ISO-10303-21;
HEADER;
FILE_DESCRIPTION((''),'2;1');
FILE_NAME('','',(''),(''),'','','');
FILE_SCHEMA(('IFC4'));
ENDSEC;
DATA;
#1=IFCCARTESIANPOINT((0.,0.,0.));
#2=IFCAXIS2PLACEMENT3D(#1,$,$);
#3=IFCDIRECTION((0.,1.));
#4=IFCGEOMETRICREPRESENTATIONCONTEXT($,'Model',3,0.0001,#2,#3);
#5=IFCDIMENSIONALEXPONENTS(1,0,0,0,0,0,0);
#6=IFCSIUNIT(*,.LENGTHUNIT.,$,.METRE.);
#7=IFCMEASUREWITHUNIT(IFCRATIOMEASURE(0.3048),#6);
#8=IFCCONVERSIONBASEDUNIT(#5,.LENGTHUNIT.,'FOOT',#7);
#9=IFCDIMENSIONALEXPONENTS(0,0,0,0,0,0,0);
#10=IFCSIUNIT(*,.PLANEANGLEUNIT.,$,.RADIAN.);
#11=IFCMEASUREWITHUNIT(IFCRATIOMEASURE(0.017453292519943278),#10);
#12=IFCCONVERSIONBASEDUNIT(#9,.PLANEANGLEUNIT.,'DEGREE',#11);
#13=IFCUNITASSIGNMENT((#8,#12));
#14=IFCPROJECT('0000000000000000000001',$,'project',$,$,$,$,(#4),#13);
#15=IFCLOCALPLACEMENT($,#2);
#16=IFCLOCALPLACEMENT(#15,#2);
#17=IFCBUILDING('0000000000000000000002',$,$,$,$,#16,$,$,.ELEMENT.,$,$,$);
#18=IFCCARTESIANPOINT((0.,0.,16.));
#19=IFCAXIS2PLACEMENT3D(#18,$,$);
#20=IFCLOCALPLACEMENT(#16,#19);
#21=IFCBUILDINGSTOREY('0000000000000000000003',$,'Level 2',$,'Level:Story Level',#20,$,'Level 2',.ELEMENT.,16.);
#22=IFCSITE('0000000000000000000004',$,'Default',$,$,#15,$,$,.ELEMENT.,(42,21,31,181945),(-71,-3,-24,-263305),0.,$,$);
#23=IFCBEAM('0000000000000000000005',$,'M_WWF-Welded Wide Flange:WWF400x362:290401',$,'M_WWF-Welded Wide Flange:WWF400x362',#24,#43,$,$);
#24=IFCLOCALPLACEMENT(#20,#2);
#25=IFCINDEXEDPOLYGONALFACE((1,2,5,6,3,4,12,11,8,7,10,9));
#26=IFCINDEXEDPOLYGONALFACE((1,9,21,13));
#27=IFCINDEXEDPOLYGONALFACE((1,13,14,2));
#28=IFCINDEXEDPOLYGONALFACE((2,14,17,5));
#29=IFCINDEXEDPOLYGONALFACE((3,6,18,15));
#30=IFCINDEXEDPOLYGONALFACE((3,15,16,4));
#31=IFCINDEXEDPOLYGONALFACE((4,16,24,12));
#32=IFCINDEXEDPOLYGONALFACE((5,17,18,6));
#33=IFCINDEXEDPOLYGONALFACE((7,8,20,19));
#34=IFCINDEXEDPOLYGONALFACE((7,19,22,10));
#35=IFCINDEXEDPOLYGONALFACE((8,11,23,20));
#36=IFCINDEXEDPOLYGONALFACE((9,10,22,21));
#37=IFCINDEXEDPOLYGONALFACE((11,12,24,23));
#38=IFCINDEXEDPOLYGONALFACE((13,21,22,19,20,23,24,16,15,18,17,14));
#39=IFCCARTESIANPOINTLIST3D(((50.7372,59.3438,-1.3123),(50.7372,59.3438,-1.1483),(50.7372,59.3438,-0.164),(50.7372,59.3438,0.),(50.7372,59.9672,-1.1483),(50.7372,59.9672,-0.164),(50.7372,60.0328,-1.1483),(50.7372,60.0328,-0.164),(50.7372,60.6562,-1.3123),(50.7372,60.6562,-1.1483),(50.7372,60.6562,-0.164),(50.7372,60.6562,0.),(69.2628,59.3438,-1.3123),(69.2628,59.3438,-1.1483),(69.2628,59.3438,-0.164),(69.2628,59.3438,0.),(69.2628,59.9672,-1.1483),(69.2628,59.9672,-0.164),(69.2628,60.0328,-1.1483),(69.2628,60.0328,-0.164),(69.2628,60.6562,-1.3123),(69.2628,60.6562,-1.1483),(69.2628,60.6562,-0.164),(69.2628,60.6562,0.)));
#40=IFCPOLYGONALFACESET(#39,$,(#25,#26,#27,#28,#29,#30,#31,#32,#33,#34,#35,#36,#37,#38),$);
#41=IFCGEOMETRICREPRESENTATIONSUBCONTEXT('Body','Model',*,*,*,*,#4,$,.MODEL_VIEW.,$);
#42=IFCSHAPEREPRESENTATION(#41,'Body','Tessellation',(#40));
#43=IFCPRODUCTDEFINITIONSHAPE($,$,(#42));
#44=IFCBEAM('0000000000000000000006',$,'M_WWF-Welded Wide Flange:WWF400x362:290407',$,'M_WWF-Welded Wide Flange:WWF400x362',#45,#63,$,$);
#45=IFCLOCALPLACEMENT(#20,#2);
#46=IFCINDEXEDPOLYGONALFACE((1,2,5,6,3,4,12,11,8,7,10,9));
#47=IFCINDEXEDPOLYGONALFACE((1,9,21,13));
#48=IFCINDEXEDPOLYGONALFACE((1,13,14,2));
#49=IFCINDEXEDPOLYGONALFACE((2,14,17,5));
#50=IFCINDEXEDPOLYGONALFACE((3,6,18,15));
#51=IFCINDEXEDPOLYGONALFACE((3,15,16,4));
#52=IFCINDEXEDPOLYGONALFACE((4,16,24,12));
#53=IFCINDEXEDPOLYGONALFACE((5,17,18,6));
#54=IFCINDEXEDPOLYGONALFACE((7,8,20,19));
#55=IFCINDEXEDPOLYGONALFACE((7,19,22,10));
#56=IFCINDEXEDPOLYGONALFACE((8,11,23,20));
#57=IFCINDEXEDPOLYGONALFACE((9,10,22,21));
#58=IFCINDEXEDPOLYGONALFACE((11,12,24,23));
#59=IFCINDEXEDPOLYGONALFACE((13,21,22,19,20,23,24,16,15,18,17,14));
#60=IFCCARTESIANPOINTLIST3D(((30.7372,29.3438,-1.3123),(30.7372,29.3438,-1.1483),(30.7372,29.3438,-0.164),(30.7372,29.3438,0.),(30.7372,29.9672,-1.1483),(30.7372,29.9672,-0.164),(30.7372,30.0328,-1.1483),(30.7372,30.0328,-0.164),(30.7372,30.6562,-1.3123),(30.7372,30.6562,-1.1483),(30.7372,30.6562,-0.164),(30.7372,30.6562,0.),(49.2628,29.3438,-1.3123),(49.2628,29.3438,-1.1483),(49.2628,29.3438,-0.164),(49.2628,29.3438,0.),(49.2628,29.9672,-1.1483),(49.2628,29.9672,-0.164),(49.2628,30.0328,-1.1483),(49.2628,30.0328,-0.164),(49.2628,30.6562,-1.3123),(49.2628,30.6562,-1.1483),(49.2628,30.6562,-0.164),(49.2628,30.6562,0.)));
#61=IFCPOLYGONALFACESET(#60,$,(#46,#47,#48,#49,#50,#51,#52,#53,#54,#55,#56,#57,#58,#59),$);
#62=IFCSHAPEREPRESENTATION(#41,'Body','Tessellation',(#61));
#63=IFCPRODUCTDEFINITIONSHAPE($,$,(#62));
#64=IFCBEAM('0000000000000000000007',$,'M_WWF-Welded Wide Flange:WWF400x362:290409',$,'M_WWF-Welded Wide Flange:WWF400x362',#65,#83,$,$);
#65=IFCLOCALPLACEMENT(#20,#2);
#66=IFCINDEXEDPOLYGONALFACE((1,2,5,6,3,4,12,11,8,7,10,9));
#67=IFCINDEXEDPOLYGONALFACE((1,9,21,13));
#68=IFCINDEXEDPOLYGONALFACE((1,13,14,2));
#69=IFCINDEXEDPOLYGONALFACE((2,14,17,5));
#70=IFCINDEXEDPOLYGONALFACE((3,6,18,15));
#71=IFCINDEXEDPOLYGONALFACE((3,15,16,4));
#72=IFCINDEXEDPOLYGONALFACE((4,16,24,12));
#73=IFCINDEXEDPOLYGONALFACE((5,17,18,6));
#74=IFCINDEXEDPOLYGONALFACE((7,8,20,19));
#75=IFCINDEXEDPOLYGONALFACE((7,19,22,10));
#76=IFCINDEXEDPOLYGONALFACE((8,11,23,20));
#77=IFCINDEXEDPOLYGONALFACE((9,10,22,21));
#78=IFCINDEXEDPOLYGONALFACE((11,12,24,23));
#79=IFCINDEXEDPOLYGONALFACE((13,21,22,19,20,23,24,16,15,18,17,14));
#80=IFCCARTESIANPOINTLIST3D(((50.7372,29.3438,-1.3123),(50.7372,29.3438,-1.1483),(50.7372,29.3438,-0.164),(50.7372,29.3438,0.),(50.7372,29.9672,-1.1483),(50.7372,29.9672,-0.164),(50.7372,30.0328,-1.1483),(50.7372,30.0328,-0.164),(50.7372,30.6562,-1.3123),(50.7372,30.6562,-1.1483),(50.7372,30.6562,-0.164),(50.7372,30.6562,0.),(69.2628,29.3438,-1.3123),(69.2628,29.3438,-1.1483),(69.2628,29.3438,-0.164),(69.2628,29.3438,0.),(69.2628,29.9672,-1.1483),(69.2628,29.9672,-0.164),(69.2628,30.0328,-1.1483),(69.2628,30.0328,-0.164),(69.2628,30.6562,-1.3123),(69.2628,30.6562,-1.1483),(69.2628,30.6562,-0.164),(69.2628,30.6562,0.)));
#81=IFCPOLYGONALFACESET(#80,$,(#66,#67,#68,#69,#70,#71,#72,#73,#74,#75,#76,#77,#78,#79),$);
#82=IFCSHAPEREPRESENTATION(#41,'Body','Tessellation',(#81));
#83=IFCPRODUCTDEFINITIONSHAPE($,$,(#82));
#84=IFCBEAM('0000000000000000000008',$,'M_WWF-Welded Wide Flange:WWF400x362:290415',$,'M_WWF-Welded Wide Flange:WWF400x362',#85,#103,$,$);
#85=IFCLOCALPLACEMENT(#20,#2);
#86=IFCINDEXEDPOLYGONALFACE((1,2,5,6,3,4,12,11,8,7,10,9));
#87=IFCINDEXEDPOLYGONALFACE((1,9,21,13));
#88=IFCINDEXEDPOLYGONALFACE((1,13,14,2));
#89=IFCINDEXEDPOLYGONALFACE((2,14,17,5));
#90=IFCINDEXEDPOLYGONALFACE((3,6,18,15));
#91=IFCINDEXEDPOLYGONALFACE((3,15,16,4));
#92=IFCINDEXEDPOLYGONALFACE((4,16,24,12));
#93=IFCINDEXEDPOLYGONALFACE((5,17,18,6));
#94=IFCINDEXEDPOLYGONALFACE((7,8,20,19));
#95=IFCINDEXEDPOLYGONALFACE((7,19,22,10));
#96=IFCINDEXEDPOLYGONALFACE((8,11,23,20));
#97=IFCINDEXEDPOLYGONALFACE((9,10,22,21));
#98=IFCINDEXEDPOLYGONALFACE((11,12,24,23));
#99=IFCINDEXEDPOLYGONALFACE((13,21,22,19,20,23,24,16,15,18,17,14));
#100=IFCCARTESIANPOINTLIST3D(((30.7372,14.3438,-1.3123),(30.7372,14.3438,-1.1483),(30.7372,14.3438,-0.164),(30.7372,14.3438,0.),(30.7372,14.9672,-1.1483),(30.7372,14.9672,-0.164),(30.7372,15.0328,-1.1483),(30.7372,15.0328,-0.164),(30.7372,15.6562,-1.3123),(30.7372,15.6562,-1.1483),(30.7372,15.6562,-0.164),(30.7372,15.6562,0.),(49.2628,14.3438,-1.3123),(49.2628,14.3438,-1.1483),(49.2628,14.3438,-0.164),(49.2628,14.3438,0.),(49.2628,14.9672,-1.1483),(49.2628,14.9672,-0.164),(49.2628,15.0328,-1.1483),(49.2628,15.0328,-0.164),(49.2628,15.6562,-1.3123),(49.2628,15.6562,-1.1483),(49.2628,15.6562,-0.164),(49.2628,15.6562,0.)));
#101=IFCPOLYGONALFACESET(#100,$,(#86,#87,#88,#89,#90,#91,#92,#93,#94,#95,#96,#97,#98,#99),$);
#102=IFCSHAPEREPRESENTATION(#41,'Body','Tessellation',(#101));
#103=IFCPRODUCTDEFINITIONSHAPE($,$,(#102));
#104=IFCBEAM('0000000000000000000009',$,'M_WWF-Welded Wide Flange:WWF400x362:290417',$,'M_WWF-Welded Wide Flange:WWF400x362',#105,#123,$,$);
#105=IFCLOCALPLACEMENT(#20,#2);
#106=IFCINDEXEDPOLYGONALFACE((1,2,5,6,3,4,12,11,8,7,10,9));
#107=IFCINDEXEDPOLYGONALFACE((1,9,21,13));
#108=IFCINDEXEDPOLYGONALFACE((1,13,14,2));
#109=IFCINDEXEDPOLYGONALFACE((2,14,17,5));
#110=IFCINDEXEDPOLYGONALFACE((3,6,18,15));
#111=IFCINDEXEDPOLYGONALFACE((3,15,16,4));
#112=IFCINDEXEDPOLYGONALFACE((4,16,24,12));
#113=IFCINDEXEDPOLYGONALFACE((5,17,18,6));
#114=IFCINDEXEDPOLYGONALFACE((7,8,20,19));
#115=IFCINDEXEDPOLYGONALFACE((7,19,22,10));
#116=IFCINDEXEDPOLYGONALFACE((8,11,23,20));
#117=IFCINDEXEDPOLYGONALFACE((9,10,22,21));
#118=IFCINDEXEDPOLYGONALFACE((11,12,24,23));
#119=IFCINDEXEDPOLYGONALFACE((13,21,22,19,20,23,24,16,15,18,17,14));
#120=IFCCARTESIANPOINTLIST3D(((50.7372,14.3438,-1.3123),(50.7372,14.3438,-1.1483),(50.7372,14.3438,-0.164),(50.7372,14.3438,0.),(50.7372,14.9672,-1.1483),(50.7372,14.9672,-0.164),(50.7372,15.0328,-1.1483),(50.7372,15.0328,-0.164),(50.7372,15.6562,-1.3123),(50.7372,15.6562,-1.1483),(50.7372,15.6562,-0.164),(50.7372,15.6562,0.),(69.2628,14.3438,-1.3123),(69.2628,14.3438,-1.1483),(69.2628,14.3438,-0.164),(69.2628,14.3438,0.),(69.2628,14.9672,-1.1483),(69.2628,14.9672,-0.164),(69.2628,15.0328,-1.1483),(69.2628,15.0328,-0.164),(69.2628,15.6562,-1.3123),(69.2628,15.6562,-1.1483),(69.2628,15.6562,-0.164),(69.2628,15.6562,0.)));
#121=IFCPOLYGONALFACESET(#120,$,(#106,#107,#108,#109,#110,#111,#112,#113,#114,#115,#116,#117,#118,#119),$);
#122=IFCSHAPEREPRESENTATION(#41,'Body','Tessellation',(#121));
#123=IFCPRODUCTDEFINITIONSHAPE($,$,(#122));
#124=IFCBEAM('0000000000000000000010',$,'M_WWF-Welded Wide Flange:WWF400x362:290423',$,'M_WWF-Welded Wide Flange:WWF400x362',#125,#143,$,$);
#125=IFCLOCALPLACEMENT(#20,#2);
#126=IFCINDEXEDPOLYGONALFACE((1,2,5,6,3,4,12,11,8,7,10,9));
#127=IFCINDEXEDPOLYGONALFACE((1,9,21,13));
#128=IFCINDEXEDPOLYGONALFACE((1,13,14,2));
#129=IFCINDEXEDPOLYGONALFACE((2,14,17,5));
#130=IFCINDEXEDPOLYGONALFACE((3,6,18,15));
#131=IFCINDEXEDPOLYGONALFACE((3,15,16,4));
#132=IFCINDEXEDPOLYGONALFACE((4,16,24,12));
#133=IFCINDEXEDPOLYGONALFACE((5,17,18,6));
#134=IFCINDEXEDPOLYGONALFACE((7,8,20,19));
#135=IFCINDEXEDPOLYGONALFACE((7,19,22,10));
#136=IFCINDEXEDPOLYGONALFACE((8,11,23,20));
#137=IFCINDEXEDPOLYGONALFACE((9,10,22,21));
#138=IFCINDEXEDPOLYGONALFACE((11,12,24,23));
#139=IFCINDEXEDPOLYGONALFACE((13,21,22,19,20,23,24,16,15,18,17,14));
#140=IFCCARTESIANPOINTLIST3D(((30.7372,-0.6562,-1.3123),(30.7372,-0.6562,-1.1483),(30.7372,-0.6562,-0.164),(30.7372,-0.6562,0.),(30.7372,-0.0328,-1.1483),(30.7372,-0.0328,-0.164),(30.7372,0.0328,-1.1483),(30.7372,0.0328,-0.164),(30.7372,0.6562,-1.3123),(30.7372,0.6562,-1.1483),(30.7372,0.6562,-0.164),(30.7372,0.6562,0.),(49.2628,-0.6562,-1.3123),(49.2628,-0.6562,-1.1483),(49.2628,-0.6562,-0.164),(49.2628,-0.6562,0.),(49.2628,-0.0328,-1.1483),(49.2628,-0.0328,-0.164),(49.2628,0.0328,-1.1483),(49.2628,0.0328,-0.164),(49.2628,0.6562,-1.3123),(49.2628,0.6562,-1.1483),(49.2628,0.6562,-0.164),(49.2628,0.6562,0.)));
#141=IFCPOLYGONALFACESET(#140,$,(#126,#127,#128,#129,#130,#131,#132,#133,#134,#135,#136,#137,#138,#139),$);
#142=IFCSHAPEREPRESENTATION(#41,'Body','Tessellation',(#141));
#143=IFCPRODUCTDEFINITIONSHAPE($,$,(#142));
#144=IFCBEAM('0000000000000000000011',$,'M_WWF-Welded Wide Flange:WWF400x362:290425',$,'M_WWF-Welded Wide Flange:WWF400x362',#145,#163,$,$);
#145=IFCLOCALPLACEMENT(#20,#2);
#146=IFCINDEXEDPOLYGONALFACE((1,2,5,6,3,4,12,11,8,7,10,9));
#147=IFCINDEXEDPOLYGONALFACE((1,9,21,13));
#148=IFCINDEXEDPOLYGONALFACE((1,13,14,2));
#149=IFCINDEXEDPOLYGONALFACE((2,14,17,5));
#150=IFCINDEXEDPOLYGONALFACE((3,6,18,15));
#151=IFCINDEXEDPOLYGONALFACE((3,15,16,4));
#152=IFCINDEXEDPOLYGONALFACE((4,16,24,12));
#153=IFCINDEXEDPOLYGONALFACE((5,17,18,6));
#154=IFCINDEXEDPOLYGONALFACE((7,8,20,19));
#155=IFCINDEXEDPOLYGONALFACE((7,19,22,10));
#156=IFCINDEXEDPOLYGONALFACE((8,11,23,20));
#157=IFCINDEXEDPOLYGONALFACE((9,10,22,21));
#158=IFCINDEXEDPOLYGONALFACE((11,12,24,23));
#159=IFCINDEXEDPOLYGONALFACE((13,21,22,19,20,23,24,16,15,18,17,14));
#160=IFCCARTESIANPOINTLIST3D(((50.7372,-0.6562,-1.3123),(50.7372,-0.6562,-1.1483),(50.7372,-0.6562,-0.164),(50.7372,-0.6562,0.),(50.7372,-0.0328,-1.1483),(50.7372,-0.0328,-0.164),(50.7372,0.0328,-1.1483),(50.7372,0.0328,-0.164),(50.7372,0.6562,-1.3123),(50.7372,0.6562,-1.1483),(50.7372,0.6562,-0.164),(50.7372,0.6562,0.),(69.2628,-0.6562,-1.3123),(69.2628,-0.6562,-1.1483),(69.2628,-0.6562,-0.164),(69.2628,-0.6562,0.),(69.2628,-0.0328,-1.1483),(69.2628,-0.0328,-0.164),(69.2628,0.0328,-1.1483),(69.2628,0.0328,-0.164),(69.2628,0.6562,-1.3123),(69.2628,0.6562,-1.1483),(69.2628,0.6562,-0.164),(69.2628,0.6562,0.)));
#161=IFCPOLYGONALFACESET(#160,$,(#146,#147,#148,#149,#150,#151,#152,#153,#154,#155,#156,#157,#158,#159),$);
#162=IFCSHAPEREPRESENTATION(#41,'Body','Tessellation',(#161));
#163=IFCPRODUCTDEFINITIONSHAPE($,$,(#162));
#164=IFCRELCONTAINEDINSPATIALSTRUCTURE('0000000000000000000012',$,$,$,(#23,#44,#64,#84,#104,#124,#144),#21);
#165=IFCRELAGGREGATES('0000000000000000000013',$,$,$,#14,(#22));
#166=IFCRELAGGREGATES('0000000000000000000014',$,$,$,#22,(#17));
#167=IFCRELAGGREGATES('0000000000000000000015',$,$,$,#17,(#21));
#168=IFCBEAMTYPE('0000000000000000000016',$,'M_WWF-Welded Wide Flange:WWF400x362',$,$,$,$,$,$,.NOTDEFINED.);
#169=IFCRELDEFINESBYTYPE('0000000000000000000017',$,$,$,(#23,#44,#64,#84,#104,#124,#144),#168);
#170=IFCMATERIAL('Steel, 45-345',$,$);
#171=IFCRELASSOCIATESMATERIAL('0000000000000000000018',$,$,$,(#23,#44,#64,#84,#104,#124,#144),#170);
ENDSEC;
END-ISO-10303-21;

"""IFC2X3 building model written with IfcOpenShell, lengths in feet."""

from ifc_helpers import new_model, entity, si_unit, converted_unit, direction, frame, frame_2d, origin, place, context, subcontext, project, spatial, i_section, extrude, material, type_object, element, save


model = new_model("IFC2X3")

# Units and contexts
model_context = context("Model", 3, precision=0.0001, world=origin(), true_north=direction((0.0, 1.0)))
body_context = subcontext(model_context, "Body", "Model", "MODEL_VIEW")
ifc_project = project(units=[converted_unit("LENGTHUNIT", "FOOT", entity("IfcRatioMeasure", 0.3048), si_unit("LENGTHUNIT", "METRE"), dimensions=[1, 0, 0, 0, 0, 0, 0]), converted_unit("PLANEANGLEUNIT", "DEGREE", entity("IfcRatioMeasure", 0.017453292519943278), si_unit("PLANEANGLEUNIT", "RADIAN"), dimensions=[0, 0, 0, 0, 0, 0, 0])], contexts=[model_context])

# Site, building, storey
site_placement = place(None, origin())
site = spatial("IfcSite", under=ifc_project, at=site_placement, Name="Default", CompositionType="ELEMENT", RefLatitude=(42, 21, 31, 181945), RefLongitude=(-71, -3, -24, -263305), RefElevation=0.0)
building_placement = place(site_placement, origin())
building = spatial("IfcBuilding", under=site, at=building_placement, CompositionType="ELEMENT")
storey_placement = place(building_placement, frame((0.0, 0.0, 16.0)))
storey = spatial("IfcBuildingStorey", under=building, at=storey_placement, Name="Level 2", ObjectType="Level:Story Level", LongName="Level 2", CompositionType="ELEMENT", Elevation=16.0)

# Shared definitions
ifc_material = material(Name="Steel, 45-345")

# Beams
beam_type = type_object("IfcBeamType", Name="M_WWF-Welded Wide Flange:WWF400x362", PredefinedType="NOTDEFINED")
beam_1_placement = place(storey_placement, frame((50.0, 60.0, 0.0)))
element("IfcBeam", 1, at=beam_1_placement, inside=storey, type_object=beam_type, material=ifc_material, Name="M_WWF-Welded Wide Flange:WWF400x362:290401", ObjectType="M_WWF-Welded Wide Flange:WWF400x362", context=body_context, shape_type="SweptSolid", body=[
    extrude(i_section(OverallWidth=1.3123, OverallDepth=1.3123, WebThickness=0.0656, FlangeThickness=0.164, at=frame_2d((0.0, 0.0), x_axis=(0.0, 1.0))), frame((0.7372, 0.0, -0.6562), z_axis=(1.0, 0.0, 0.0), x_axis=(0.0, 0.0, -1.0)), (0.0, 0.0, 1.0), 18.5256),
])
beam_2_placement = place(storey_placement, frame((30.0, 30.0, 0.0)))
element("IfcBeam", 2, at=beam_2_placement, inside=storey, type_object=beam_type, material=ifc_material, Name="M_WWF-Welded Wide Flange:WWF400x362:290407", ObjectType="M_WWF-Welded Wide Flange:WWF400x362", context=body_context, shape_type="SweptSolid", body=[
    extrude(i_section(OverallWidth=1.3123, OverallDepth=1.3123, WebThickness=0.0656, FlangeThickness=0.164, at=frame_2d((0.0, 0.0), x_axis=(0.0, 1.0))), frame((0.7372, 0.0, -0.6562), z_axis=(1.0, 0.0, 0.0), x_axis=(0.0, 0.0, -1.0)), (0.0, 0.0, 1.0), 18.5256),
])
beam_3_placement = place(storey_placement, frame((50.0, 30.0, 0.0)))
element("IfcBeam", 3, at=beam_3_placement, inside=storey, type_object=beam_type, material=ifc_material, Name="M_WWF-Welded Wide Flange:WWF400x362:290409", ObjectType="M_WWF-Welded Wide Flange:WWF400x362", context=body_context, shape_type="SweptSolid", body=[
    extrude(i_section(OverallWidth=1.3123, OverallDepth=1.3123, WebThickness=0.0656, FlangeThickness=0.164, at=frame_2d((0.0, 0.0), x_axis=(0.0, 1.0))), frame((0.7372, 0.0, -0.6562), z_axis=(1.0, 0.0, 0.0), x_axis=(0.0, 0.0, -1.0)), (0.0, 0.0, 1.0), 18.5256),
])
beam_4_placement = place(storey_placement, frame((30.0, 15.0, 0.0)))
element("IfcBeam", 4, at=beam_4_placement, inside=storey, type_object=beam_type, material=ifc_material, Name="M_WWF-Welded Wide Flange:WWF400x362:290415", ObjectType="M_WWF-Welded Wide Flange:WWF400x362", context=body_context, shape_type="SweptSolid", body=[
    extrude(i_section(OverallWidth=1.3123, OverallDepth=1.3123, WebThickness=0.0656, FlangeThickness=0.164, at=frame_2d((0.0, 0.0), x_axis=(0.0, 1.0))), frame((0.7372, 0.0, -0.6562), z_axis=(1.0, 0.0, 0.0), x_axis=(0.0, 0.0, -1.0)), (0.0, 0.0, 1.0), 18.5256),
])
beam_5_placement = place(storey_placement, frame((50.0, 15.0, 0.0)))
element("IfcBeam", 5, at=beam_5_placement, inside=storey, type_object=beam_type, material=ifc_material, Name="M_WWF-Welded Wide Flange:WWF400x362:290417", ObjectType="M_WWF-Welded Wide Flange:WWF400x362", context=body_context, shape_type="SweptSolid", body=[
    extrude(i_section(OverallWidth=1.3123, OverallDepth=1.3123, WebThickness=0.0656, FlangeThickness=0.164, at=frame_2d((0.0, 0.0), x_axis=(0.0, 1.0))), frame((0.7372, 0.0, -0.6562), z_axis=(1.0, 0.0, 0.0), x_axis=(0.0, 0.0, -1.0)), (0.0, 0.0, 1.0), 18.5256),
])
beam_6_placement = place(storey_placement, frame((30.0, 0.0, 0.0)))
element("IfcBeam", 6, at=beam_6_placement, inside=storey, type_object=beam_type, material=ifc_material, Name="M_WWF-Welded Wide Flange:WWF400x362:290423", ObjectType="M_WWF-Welded Wide Flange:WWF400x362", context=body_context, shape_type="SweptSolid", body=[
    extrude(i_section(OverallWidth=1.3123, OverallDepth=1.3123, WebThickness=0.0656, FlangeThickness=0.164, at=frame_2d((0.0, 0.0), x_axis=(0.0, 1.0))), frame((0.7372, 0.0, -0.6562), z_axis=(1.0, 0.0, 0.0), x_axis=(0.0, 0.0, -1.0)), (0.0, 0.0, 1.0), 18.5256),
])
beam_7_placement = place(storey_placement, frame((50.0, 0.0, 0.0)))
element("IfcBeam", 7, at=beam_7_placement, inside=storey, type_object=beam_type, material=ifc_material, Name="M_WWF-Welded Wide Flange:WWF400x362:290425", ObjectType="M_WWF-Welded Wide Flange:WWF400x362", context=body_context, shape_type="SweptSolid", body=[
    extrude(i_section(OverallWidth=1.3123, OverallDepth=1.3123, WebThickness=0.0656, FlangeThickness=0.164, at=frame_2d((0.0, 0.0), x_axis=(0.0, 1.0))), frame((0.7372, 0.0, -0.6562), z_axis=(1.0, 0.0, 0.0), x_axis=(0.0, 0.0, -1.0)), (0.0, 0.0, 1.0), 18.5256),
])

save(model, "model.ifc")
